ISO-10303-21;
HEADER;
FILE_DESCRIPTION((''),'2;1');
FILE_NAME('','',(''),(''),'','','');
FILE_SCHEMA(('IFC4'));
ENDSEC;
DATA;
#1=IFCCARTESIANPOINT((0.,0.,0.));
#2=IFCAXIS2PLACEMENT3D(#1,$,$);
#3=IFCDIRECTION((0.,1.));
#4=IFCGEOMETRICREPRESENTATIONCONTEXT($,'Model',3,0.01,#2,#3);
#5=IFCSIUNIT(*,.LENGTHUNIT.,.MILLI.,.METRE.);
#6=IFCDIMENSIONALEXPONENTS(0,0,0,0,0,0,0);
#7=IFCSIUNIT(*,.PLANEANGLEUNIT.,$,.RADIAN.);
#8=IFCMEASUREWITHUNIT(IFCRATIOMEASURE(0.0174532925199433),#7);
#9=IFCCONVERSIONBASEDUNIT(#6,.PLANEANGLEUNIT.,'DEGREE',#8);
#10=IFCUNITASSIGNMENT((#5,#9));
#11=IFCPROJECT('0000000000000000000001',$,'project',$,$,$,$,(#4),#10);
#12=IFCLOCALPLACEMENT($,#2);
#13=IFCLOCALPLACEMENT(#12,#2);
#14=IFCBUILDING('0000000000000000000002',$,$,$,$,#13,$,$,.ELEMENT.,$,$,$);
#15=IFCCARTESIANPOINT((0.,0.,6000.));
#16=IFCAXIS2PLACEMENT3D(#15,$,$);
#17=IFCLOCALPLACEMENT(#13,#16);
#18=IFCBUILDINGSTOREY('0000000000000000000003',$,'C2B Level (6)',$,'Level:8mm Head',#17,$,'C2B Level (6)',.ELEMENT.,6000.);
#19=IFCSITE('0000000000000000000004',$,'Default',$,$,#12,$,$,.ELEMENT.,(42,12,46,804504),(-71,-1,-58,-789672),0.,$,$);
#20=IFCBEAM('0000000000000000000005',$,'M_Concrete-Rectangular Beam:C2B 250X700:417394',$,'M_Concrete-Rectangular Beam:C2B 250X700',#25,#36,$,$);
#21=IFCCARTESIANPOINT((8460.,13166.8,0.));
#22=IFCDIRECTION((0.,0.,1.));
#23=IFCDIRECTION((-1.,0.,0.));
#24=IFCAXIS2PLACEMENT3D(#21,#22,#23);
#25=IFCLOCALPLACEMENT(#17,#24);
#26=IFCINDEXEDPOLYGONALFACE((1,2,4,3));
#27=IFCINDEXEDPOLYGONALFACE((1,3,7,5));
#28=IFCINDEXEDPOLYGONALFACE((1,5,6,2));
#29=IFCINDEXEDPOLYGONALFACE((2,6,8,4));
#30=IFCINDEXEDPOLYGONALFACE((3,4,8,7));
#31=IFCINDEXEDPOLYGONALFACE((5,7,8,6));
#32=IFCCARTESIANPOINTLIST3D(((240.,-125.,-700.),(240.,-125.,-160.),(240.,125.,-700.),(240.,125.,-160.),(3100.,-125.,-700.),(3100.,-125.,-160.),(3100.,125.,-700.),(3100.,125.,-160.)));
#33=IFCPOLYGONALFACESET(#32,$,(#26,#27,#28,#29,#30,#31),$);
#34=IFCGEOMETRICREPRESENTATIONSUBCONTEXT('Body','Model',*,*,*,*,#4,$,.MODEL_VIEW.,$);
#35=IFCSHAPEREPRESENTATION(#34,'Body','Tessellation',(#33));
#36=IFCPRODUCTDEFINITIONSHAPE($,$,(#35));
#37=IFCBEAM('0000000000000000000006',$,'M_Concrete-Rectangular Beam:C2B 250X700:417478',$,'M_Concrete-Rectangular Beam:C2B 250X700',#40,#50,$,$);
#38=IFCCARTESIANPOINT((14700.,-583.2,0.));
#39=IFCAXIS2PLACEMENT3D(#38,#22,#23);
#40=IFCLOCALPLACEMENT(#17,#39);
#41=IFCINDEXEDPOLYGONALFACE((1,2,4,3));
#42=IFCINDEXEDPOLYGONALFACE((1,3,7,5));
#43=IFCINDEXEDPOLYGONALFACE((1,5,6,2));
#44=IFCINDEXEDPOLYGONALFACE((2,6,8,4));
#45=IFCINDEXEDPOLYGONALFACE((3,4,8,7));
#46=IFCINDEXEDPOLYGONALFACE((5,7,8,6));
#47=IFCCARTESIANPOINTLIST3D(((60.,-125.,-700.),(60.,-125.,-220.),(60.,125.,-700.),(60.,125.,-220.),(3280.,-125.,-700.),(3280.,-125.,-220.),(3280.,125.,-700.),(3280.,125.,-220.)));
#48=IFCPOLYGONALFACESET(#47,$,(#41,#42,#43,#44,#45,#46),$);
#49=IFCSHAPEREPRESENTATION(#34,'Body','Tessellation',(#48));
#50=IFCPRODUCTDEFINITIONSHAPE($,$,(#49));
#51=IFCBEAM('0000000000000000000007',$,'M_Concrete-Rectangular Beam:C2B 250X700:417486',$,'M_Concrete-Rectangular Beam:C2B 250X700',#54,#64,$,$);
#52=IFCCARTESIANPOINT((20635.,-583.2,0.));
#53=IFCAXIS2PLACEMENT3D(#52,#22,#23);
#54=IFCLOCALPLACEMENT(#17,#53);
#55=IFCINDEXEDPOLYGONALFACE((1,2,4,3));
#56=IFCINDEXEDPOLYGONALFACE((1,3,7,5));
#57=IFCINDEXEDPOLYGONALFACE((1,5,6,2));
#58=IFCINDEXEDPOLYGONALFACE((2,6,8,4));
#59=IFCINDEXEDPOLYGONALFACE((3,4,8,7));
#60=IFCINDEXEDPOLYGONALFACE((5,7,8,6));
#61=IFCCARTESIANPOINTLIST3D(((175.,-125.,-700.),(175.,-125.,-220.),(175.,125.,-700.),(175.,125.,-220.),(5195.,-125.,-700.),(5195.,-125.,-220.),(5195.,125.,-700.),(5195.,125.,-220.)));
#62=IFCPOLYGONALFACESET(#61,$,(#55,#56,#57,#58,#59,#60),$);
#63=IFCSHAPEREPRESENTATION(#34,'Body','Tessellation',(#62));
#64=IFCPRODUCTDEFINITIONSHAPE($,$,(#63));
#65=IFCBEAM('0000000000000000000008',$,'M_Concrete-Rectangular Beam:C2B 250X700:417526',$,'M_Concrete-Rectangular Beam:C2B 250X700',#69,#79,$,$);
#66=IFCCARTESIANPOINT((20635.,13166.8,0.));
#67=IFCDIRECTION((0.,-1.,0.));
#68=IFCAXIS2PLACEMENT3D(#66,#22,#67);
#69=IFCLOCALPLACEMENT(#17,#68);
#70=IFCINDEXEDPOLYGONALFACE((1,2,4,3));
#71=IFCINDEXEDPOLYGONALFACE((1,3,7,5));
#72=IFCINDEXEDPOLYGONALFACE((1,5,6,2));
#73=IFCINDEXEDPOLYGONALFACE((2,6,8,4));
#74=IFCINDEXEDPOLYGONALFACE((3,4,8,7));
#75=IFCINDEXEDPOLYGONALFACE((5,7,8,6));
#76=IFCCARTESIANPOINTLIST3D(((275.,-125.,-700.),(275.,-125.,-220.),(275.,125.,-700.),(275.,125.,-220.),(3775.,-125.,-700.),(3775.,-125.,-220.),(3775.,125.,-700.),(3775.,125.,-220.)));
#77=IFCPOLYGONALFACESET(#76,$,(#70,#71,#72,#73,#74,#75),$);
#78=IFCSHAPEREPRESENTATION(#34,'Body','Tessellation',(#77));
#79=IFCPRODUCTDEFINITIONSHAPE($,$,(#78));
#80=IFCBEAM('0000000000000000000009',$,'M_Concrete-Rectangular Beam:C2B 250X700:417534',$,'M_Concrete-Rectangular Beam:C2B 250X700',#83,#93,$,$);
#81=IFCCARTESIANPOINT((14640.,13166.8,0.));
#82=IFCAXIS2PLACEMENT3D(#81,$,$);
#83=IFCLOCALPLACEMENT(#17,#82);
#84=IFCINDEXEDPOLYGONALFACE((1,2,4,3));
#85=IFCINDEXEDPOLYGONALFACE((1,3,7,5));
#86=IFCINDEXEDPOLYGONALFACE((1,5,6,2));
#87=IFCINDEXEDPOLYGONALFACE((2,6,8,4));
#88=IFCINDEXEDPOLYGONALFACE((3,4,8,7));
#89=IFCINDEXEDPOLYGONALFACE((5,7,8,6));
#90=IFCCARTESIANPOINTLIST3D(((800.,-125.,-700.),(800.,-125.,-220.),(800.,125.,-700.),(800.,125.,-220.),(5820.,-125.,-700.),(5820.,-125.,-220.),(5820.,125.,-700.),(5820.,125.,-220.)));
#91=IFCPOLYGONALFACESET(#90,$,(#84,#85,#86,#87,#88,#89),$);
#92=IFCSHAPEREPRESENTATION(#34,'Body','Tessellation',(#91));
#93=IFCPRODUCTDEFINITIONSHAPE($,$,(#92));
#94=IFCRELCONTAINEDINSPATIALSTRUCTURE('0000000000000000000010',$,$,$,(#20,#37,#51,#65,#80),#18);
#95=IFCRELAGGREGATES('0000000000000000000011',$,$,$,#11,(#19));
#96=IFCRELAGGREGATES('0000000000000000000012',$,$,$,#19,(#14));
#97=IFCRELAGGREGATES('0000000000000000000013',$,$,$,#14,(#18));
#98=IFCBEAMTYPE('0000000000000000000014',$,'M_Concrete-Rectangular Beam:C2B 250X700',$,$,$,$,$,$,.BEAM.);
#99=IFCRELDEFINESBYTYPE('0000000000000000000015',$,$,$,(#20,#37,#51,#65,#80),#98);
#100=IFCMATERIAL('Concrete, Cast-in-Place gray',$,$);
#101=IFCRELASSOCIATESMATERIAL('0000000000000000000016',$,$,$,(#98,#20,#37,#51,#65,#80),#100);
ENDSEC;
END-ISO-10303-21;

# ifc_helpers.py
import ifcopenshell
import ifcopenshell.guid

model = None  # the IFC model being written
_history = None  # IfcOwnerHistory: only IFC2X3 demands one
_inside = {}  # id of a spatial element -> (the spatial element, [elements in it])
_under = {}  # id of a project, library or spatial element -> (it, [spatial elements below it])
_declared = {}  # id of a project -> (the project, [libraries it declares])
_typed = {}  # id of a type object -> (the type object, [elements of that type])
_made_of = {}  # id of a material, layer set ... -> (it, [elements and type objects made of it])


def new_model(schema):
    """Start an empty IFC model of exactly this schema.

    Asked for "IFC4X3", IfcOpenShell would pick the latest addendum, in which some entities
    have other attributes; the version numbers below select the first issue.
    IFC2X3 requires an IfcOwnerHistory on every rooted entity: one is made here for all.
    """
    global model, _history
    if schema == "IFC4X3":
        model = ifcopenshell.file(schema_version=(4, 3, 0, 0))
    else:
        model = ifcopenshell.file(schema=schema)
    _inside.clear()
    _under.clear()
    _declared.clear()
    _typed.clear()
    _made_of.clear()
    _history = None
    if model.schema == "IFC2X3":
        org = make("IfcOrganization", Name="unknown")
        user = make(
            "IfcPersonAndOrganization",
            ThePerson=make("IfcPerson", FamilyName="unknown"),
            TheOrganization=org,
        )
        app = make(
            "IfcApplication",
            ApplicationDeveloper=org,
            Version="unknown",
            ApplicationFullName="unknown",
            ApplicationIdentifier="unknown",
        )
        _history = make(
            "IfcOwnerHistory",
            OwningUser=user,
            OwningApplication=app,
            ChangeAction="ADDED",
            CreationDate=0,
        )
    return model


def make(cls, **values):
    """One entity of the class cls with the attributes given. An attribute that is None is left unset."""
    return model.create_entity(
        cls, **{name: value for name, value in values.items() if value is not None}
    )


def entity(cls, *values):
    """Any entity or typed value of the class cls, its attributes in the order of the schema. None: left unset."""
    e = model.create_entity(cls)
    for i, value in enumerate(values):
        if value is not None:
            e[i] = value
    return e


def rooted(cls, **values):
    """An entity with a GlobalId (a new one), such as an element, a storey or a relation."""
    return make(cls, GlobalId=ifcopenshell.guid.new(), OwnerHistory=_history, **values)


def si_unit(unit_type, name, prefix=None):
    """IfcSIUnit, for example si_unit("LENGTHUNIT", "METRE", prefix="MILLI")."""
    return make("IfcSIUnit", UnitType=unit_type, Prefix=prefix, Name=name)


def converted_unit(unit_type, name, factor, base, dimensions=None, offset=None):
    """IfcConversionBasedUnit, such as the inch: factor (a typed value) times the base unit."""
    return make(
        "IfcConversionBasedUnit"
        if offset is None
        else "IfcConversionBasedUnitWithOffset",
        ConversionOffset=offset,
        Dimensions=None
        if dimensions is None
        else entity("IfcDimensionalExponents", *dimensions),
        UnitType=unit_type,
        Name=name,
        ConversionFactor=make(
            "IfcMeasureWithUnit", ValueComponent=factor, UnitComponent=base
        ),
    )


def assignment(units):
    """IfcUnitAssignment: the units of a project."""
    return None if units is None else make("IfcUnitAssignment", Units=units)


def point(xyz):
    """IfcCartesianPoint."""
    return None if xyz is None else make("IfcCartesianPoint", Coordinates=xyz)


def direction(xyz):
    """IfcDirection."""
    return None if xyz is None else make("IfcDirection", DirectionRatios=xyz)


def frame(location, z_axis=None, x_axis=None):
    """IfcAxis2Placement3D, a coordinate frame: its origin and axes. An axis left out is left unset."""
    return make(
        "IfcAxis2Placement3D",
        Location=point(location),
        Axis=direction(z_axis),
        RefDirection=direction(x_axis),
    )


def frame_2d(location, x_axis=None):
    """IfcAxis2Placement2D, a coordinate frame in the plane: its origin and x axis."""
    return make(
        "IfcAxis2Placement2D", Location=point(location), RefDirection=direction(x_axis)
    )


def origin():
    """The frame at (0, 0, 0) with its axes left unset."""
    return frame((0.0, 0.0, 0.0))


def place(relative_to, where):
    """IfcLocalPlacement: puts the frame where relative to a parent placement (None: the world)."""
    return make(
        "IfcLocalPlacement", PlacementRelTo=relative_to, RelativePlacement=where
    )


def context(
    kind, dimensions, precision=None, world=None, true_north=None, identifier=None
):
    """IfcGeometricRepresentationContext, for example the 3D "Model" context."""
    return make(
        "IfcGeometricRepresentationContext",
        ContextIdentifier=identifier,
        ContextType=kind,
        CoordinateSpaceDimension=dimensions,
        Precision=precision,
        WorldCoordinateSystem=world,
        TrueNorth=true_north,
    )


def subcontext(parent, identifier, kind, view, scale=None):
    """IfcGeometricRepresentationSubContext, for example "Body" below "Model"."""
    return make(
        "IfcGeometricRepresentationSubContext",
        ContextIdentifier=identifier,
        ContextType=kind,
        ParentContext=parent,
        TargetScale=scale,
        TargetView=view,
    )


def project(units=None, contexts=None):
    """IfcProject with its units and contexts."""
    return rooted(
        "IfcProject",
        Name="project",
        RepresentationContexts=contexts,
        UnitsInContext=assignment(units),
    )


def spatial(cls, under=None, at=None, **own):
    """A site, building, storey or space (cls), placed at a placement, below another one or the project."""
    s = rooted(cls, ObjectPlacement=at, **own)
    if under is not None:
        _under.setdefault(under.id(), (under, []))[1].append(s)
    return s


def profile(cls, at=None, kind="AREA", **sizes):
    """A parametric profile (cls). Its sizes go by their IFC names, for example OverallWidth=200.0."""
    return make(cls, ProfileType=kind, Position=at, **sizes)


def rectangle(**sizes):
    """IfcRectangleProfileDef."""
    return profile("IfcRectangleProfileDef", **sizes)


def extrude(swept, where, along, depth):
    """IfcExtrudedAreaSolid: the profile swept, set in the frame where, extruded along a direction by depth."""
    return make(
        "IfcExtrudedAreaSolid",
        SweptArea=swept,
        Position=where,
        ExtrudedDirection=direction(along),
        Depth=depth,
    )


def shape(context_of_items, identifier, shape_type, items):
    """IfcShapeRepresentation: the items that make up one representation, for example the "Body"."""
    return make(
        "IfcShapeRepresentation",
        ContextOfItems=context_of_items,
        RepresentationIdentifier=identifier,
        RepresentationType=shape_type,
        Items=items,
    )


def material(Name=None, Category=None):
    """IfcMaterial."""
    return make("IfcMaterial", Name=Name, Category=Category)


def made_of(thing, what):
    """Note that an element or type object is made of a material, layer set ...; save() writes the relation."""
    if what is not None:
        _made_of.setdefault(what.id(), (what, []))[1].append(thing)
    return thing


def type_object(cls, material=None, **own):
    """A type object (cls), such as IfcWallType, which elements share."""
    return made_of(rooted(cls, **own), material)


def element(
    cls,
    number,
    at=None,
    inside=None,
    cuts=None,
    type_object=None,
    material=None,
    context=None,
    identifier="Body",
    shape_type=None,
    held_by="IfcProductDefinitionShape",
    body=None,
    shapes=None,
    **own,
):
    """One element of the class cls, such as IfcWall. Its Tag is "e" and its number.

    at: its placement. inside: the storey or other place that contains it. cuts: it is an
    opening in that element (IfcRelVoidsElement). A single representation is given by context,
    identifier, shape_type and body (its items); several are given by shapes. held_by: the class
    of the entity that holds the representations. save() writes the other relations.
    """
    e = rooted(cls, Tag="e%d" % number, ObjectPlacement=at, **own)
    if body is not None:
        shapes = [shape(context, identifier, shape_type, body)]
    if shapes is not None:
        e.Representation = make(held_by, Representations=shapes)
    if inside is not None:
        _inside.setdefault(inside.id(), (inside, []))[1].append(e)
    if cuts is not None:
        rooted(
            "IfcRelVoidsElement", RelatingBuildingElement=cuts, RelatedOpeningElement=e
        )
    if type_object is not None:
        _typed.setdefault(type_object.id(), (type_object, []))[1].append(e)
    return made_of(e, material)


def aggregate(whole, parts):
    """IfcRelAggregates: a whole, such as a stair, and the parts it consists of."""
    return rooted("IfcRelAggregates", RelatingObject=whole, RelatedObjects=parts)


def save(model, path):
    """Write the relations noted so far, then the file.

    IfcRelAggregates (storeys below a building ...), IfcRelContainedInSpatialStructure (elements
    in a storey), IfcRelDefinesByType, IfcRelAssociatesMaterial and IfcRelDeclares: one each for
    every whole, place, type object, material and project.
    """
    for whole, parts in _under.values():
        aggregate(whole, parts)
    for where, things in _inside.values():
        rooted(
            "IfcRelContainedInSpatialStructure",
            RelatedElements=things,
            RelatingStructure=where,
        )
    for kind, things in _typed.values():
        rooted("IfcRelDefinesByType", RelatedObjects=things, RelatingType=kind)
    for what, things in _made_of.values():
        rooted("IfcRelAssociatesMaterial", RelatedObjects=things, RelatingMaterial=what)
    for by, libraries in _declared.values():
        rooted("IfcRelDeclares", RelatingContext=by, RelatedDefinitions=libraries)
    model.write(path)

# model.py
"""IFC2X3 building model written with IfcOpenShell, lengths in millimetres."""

from ifc_helpers import new_model, entity, si_unit, converted_unit, direction, frame, frame_2d, origin, place, context, subcontext, project, spatial, rectangle, extrude, material, type_object, element, save


model = new_model("IFC2X3")

# Units and contexts
model_context = context("Model", 3, precision=0.01, world=origin(), true_north=direction((0.0, 1.0)))
body_context = subcontext(model_context, "Body", "Model", "MODEL_VIEW")
ifc_project = project(units=[si_unit("LENGTHUNIT", "METRE", prefix="MILLI"), converted_unit("PLANEANGLEUNIT", "DEGREE", entity("IfcRatioMeasure", 0.0174532925199433), si_unit("PLANEANGLEUNIT", "RADIAN"), dimensions=[0, 0, 0, 0, 0, 0, 0])], contexts=[model_context])

# Site, building, storey
site_placement = place(None, origin())
site = spatial("IfcSite", under=ifc_project, at=site_placement, Name="Default", CompositionType="ELEMENT", RefLatitude=(42, 12, 46, 804504), RefLongitude=(-71, -1, -58, -789672), RefElevation=0.0)
building_placement = place(site_placement, origin())
building = spatial("IfcBuilding", under=site, at=building_placement, CompositionType="ELEMENT")
storey_placement = place(building_placement, frame((0.0, 0.0, 6000.0)))
storey = spatial("IfcBuildingStorey", under=building, at=storey_placement, Name="C2B Level (6)", ObjectType="Level:8mm Head", LongName="C2B Level (6)", CompositionType="ELEMENT", Elevation=6000.0)

# Beams
ifc_material_1 = material(Name="Concrete, Cast-in-Place gray")
beam_type_1 = type_object("IfcBeamType", Name="M_Concrete-Rectangular Beam:C2B 250X700", PredefinedType="BEAM", material=ifc_material_1)
beam_1_placement = place(storey_placement, frame((8460.0, 13166.8, 0.0), z_axis=(0.0, 0.0, 1.0), x_axis=(-1.0, 0.0, 0.0)))
element("IfcBeam", 1, at=beam_1_placement, inside=storey, type_object=beam_type_1, material=ifc_material_1, Name="M_Concrete-Rectangular Beam:C2B 250X700:417394", ObjectType="M_Concrete-Rectangular Beam:C2B 250X700", context=body_context, shape_type="SweptSolid", body=[
    extrude(rectangle(XDim=540.0, YDim=250.0, at=frame_2d((0.0, 0.0), x_axis=(1.0, 0.0))), frame((240.0, 0.0, -430.0), z_axis=(1.0, 0.0, 0.0), x_axis=(0.0, 0.0, -1.0)), (0.0, 0.0, 1.0), 2860.0),
])
beam_2_placement = place(storey_placement, frame((14700.0, -583.2, 0.0), z_axis=(0.0, 0.0, 1.0), x_axis=(-1.0, 0.0, 0.0)))
element("IfcBeam", 2, at=beam_2_placement, inside=storey, type_object=beam_type_1, material=ifc_material_1, Name="M_Concrete-Rectangular Beam:C2B 250X700:417478", ObjectType="M_Concrete-Rectangular Beam:C2B 250X700", context=body_context, shape_type="SweptSolid", body=[
    extrude(rectangle(XDim=480.0, YDim=250.0, at=frame_2d((0.0, 0.0), x_axis=(1.0, 0.0))), frame((60.0, 0.0, -460.0), z_axis=(1.0, 0.0, 0.0), x_axis=(0.0, 0.0, -1.0)), (0.0, 0.0, 1.0), 3220.0),
])
beam_3_placement = place(storey_placement, frame((20635.0, -583.2, 0.0), z_axis=(0.0, 0.0, 1.0), x_axis=(-1.0, 0.0, 0.0)))
element("IfcBeam", 3, at=beam_3_placement, inside=storey, type_object=beam_type_1, material=ifc_material_1, Name="M_Concrete-Rectangular Beam:C2B 250X700:417486", ObjectType="M_Concrete-Rectangular Beam:C2B 250X700", context=body_context, shape_type="SweptSolid", body=[
    extrude(rectangle(XDim=480.0, YDim=250.0, at=frame_2d((0.0, 0.0), x_axis=(1.0, 0.0))), frame((175.0, 0.0, -460.0), z_axis=(1.0, 0.0, 0.0), x_axis=(0.0, 0.0, -1.0)), (0.0, 0.0, 1.0), 5020.0),
])
beam_4_placement = place(storey_placement, frame((20635.0, 13166.8, 0.0), z_axis=(0.0, 0.0, 1.0), x_axis=(0.0, -1.0, 0.0)))
element("IfcBeam", 4, at=beam_4_placement, inside=storey, type_object=beam_type_1, material=ifc_material_1, Name="M_Concrete-Rectangular Beam:C2B 250X700:417526", ObjectType="M_Concrete-Rectangular Beam:C2B 250X700", context=body_context, shape_type="SweptSolid", body=[
    extrude(rectangle(XDim=480.0, YDim=250.0, at=frame_2d((0.0, 0.0), x_axis=(1.0, 0.0))), frame((275.0, 0.0, -460.0), z_axis=(1.0, 0.0, 0.0), x_axis=(0.0, 0.0, -1.0)), (0.0, 0.0, 1.0), 3500.0),
])
beam_5_placement = place(storey_placement, frame((14640.0, 13166.8, 0.0)))
element("IfcBeam", 5, at=beam_5_placement, inside=storey, type_object=beam_type_1, material=ifc_material_1, Name="M_Concrete-Rectangular Beam:C2B 250X700:417534", ObjectType="M_Concrete-Rectangular Beam:C2B 250X700", context=body_context, shape_type="SweptSolid", body=[
    extrude(rectangle(XDim=480.0, YDim=250.0, at=frame_2d((0.0, 0.0), x_axis=(1.0, 0.0))), frame((800.0, 0.0, -460.0), z_axis=(1.0, 0.0, 0.0), x_axis=(0.0, 0.0, -1.0)), (0.0, 0.0, 1.0), 5020.0),
])

save(model, "model.ifc")
